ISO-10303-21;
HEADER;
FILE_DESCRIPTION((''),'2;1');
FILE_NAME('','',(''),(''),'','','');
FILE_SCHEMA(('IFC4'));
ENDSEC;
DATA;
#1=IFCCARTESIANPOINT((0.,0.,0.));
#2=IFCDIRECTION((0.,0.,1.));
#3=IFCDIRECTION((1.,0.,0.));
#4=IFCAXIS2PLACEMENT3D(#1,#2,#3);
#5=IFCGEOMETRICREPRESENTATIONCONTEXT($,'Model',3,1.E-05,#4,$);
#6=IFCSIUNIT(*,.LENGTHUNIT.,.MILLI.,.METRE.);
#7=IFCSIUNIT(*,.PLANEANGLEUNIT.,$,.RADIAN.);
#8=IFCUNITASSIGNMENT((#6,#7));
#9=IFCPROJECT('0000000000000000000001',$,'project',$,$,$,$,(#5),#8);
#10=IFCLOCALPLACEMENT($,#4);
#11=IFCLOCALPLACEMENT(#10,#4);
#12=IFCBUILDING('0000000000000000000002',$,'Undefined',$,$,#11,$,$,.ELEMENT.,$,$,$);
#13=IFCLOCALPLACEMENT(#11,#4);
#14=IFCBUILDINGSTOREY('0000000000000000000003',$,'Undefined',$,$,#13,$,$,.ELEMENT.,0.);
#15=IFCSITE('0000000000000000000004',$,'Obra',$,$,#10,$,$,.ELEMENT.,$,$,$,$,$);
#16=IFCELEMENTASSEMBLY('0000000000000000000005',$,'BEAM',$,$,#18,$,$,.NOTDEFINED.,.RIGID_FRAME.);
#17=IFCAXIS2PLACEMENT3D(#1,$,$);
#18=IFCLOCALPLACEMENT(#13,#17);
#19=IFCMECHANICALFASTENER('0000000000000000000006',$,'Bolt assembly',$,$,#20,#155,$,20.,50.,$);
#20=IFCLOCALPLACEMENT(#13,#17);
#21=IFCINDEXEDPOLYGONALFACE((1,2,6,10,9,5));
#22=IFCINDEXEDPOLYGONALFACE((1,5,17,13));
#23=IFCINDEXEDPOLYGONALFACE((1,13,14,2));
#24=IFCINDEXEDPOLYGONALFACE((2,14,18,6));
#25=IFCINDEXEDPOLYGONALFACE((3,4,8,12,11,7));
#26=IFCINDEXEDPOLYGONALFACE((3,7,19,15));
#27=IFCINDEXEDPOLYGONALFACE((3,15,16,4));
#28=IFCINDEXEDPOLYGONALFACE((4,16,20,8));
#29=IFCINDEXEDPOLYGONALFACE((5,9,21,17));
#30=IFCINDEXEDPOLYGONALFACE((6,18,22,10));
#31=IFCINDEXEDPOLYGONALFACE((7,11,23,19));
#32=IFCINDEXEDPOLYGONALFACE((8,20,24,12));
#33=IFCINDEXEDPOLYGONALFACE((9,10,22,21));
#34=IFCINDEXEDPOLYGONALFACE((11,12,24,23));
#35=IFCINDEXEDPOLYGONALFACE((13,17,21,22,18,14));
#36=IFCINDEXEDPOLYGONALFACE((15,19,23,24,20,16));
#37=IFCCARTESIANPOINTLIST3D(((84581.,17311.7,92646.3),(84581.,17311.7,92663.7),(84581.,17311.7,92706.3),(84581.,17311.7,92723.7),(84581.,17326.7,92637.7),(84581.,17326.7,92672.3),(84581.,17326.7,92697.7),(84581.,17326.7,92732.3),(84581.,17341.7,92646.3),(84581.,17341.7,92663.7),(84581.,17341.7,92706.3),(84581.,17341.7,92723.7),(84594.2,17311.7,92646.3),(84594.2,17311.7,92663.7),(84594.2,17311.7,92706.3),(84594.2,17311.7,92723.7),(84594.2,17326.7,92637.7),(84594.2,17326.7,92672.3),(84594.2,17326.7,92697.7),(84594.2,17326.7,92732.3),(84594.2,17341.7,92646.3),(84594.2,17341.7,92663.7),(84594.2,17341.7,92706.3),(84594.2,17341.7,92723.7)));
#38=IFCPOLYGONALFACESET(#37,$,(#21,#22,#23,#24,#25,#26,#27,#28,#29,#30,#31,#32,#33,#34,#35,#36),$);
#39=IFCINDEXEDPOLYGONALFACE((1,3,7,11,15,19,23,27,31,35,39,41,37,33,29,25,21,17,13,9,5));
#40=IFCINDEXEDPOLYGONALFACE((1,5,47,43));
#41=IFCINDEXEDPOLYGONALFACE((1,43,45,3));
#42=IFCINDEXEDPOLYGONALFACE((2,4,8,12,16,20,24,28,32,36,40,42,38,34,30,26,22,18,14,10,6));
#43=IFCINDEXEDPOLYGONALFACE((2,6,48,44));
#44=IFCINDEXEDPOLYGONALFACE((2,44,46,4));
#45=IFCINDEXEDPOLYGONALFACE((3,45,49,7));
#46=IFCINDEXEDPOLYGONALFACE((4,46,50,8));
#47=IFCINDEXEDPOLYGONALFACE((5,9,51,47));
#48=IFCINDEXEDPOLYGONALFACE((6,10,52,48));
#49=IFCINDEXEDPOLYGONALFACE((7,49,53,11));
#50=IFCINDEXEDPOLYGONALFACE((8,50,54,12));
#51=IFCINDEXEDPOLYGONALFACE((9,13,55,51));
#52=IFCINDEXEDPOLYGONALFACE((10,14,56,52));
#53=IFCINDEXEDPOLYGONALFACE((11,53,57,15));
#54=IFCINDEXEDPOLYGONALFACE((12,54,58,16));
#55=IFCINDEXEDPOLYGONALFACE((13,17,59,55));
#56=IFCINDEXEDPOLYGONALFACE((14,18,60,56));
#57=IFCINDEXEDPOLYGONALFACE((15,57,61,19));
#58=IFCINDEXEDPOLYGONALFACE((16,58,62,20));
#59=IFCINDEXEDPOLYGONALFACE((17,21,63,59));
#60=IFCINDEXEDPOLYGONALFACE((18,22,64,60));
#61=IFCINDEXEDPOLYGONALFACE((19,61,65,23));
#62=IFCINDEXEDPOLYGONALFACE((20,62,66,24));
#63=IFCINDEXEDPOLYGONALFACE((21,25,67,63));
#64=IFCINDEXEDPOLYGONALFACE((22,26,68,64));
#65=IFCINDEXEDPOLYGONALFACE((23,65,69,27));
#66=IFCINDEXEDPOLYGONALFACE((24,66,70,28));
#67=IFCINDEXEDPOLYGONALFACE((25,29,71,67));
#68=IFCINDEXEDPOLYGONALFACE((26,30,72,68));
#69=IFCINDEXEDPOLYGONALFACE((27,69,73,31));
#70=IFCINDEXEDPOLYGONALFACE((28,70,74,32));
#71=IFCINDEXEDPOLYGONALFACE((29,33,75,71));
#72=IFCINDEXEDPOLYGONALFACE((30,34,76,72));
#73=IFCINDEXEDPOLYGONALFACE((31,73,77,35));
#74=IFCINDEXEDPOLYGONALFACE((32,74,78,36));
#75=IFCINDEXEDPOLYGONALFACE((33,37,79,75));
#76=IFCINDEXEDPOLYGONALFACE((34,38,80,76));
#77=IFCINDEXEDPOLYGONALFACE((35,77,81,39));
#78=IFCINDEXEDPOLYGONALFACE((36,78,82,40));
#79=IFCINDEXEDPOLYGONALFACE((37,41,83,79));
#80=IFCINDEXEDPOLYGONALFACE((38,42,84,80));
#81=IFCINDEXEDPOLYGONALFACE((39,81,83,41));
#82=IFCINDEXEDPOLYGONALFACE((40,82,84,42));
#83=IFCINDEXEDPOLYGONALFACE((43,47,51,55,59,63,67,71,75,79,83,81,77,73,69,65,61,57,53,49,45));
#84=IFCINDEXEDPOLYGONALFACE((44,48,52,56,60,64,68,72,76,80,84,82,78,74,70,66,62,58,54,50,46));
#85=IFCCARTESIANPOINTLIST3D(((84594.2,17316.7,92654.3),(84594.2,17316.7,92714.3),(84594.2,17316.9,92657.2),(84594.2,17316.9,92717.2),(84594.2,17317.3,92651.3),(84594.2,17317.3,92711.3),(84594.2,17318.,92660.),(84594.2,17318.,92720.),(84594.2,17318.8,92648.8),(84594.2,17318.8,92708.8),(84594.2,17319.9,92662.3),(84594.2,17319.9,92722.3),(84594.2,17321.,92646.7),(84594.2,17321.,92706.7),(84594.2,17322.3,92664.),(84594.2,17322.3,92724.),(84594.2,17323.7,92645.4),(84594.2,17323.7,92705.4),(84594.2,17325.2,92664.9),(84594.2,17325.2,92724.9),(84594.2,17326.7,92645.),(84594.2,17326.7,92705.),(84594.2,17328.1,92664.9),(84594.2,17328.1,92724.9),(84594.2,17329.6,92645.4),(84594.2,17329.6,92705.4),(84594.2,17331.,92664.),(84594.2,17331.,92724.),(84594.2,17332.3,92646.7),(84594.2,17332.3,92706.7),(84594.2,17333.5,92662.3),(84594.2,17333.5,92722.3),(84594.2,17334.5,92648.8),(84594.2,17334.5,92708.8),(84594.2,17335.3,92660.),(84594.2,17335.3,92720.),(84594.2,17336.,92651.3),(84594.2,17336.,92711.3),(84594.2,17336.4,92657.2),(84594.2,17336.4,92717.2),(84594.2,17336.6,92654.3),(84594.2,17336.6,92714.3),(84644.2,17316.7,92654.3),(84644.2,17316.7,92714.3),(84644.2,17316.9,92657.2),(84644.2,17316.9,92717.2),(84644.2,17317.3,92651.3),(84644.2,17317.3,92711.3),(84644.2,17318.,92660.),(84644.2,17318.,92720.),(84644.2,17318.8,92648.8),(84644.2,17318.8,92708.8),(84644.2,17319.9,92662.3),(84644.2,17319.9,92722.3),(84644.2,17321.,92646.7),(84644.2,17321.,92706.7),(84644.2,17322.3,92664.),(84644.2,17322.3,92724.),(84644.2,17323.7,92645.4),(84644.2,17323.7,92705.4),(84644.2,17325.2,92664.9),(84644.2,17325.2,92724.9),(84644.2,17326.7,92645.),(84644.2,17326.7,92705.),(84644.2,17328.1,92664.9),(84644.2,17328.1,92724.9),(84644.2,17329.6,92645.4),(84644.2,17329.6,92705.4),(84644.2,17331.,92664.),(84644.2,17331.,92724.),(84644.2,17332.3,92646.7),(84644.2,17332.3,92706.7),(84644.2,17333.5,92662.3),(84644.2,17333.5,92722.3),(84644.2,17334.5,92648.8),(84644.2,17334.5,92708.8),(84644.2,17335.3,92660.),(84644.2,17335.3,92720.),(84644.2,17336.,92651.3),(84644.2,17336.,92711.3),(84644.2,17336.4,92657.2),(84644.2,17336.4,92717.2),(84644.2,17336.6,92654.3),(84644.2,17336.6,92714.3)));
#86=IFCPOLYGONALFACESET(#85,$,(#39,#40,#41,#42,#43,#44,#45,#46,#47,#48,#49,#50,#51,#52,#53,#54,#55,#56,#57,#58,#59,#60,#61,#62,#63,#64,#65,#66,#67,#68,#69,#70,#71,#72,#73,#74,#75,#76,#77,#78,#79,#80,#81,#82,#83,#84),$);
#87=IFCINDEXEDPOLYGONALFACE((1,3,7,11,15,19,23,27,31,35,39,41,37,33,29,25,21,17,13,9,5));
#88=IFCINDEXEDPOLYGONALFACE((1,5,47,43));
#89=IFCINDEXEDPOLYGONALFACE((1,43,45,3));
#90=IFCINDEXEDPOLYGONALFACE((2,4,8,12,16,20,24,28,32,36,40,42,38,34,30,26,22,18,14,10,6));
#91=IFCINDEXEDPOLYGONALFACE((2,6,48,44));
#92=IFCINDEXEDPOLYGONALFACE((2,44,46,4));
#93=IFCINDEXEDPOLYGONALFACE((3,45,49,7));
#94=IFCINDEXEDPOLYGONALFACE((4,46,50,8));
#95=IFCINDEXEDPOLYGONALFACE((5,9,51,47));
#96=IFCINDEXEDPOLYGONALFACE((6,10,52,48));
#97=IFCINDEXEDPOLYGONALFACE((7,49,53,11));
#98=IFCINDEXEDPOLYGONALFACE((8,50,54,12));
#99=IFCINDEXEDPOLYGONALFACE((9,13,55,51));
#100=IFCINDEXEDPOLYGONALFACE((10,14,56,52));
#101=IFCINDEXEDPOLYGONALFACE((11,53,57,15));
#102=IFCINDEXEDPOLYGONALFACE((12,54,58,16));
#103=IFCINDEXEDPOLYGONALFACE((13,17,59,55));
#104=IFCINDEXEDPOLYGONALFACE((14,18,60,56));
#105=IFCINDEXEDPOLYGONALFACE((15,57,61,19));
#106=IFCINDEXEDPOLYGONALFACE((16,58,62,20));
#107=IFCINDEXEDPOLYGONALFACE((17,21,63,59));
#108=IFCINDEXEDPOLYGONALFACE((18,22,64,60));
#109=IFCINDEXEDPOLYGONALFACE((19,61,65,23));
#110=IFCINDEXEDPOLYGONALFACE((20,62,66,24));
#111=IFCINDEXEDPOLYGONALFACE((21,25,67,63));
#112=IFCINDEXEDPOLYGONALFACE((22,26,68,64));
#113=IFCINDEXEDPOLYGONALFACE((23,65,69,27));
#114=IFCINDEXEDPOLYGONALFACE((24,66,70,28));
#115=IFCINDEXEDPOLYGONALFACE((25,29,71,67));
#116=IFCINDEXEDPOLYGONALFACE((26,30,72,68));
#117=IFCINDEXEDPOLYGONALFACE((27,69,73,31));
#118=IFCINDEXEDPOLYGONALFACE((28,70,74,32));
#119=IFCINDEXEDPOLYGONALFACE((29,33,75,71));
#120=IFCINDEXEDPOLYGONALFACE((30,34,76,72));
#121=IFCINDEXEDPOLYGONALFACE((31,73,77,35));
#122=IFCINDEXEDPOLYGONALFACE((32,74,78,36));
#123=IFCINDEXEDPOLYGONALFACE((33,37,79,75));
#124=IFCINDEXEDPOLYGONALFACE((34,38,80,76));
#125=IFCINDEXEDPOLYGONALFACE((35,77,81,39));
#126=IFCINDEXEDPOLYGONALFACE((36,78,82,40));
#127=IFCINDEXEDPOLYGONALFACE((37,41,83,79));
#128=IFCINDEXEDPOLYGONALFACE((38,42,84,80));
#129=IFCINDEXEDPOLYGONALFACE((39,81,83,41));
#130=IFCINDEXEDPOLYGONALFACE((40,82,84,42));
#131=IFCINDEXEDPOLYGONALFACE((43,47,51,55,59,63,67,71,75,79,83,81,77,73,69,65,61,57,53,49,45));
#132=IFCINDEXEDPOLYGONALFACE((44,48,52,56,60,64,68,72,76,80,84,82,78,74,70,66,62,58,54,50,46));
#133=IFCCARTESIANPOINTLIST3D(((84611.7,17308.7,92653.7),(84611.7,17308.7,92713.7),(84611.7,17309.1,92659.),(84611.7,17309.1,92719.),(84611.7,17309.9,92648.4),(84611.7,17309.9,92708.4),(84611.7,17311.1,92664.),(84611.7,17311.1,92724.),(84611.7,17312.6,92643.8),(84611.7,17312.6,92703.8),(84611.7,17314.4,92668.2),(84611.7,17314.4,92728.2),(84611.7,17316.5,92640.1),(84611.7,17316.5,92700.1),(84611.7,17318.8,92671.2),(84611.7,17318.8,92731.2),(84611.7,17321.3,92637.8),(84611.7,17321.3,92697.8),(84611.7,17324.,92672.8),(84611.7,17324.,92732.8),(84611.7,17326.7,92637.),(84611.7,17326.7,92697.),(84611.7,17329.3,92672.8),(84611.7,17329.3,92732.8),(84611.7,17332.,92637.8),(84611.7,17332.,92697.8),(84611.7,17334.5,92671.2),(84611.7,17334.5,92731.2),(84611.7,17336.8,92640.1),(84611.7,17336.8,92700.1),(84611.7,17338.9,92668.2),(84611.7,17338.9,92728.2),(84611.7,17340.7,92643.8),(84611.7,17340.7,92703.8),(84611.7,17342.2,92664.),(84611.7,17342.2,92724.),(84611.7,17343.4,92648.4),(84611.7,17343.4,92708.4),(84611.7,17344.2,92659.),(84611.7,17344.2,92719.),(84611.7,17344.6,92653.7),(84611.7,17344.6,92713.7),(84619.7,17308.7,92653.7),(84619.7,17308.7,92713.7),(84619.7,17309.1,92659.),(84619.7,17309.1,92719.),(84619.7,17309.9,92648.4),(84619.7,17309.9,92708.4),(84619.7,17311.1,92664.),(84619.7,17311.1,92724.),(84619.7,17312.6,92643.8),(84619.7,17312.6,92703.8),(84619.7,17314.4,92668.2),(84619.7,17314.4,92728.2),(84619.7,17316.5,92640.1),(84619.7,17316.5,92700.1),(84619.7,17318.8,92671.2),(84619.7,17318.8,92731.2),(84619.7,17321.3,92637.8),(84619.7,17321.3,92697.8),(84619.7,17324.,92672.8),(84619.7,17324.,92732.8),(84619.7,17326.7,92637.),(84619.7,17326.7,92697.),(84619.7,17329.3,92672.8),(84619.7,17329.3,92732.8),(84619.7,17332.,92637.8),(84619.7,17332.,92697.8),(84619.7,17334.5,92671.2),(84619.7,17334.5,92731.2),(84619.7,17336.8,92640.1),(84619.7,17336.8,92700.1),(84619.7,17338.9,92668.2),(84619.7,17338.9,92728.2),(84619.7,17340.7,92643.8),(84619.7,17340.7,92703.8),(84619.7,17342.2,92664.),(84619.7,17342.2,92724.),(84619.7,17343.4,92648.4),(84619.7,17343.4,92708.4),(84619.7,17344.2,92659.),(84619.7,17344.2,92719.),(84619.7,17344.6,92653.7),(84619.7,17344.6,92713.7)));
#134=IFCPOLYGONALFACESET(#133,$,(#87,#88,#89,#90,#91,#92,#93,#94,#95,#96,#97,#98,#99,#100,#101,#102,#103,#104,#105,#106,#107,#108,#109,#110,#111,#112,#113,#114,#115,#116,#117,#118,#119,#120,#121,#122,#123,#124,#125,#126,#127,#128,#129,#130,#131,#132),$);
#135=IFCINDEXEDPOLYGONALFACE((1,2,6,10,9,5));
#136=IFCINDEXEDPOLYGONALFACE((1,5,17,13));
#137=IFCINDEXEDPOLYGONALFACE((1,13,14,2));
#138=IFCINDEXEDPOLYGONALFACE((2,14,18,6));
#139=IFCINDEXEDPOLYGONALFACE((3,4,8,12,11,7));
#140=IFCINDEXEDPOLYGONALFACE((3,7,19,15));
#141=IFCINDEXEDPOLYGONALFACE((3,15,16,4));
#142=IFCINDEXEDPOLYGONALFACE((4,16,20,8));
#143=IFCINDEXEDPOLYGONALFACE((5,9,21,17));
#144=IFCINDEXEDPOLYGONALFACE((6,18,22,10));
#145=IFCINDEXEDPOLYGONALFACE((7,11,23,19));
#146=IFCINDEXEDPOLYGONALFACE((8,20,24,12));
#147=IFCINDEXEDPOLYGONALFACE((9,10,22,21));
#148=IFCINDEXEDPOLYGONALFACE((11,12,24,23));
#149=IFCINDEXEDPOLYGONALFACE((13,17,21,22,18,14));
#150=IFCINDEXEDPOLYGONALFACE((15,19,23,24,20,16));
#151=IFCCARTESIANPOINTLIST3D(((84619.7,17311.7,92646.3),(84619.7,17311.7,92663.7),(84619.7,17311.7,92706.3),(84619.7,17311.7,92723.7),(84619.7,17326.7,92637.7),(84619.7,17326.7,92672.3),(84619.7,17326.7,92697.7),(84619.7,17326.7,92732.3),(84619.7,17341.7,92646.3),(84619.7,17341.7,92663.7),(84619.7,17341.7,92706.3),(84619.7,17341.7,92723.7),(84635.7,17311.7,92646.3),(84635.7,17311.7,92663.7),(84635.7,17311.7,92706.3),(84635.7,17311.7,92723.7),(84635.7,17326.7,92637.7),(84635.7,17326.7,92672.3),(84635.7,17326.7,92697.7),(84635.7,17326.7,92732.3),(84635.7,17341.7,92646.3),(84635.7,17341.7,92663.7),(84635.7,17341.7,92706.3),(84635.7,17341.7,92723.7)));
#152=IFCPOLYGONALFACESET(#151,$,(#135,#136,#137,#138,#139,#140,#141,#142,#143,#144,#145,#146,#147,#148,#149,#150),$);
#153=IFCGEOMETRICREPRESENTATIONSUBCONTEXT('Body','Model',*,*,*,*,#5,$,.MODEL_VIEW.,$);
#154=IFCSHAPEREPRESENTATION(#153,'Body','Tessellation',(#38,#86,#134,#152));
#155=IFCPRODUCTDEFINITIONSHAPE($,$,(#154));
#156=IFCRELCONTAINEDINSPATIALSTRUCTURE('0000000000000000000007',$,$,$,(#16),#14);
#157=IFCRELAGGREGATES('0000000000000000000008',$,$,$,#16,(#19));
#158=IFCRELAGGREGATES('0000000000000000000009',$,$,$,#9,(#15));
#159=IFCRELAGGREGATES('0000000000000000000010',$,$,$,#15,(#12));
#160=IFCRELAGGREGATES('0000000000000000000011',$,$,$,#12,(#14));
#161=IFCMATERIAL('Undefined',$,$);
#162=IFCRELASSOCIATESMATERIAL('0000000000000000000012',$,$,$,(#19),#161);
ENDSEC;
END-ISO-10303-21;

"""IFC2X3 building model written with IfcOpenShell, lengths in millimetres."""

from ifc_helpers import new_model, si_unit, frame, origin_with_axes, origin_2d_with_axis, place, context, subcontext, project, spatial, polyline, circle, outline, extrude, source, transform, mapped, material, element, aggregate, save


model = new_model("IFC2X3")

# Units and contexts
model_context = context("Model", 3, precision=1e-05, world=origin_with_axes())
body_context = subcontext(model_context, "Body", "Model", "MODEL_VIEW")
ifc_project = project(units=[si_unit("LENGTHUNIT", "METRE", prefix="MILLI"), si_unit("PLANEANGLEUNIT", "RADIAN")], contexts=[model_context])

# Site, building, storey
site_placement = place(None, origin_with_axes())
site = spatial("IfcSite", under=ifc_project, at=site_placement, Name="Obra", CompositionType="ELEMENT")
building_placement = place(site_placement, origin_with_axes())
building = spatial("IfcBuilding", under=site, at=building_placement, Name="Undefined", CompositionType="ELEMENT")
storey_placement = place(building_placement, origin_with_axes())
storey = spatial("IfcBuildingStorey", under=building, at=storey_placement, Name="Undefined", CompositionType="ELEMENT", Elevation=0.0)

# Shared definitions
ifc_material_1 = material(Name="Undefined")

# Shared definitions
shared_shape_1 = source(origin_with_axes(), body_context, "Body", "SweptSolid", [
    extrude(outline(polyline([(17.3, 0.0), (8.7, 15.0), (-8.7, 15.0), (-17.3, 0.0), (-8.7, -15.0), (8.7, -15.0), (17.3, 0.0)])), frame((0.0, -27.0, 0.0), z_axis=(0.0, 1.0, 0.0), x_axis=(1.0, 0.0, 0.0)), (0.0, 0.0, 1.0), 13.2),
    extrude(circle(Radius=10.0, at=origin_2d_with_axis()), frame((0.0, -13.8, 0.0), z_axis=(0.0, 1.0, 0.0), x_axis=(1.0, 0.0, 0.0)), (0.0, 0.0, 1.0), 50.0),
    extrude(circle(Radius=18.0, at=origin_2d_with_axis()), frame((0.0, 3.7, 0.0), z_axis=(0.0, 1.0, 0.0), x_axis=(1.0, 0.0, 0.0)), (0.0, 0.0, 1.0), 8.0),
    extrude(outline(polyline([(17.3, 0.0), (8.7, 15.0), (-8.7, 15.0), (-17.3, 0.0), (-8.7, -15.0), (8.7, -15.0), (17.3, 0.0)])), frame((0.0, 11.7, 0.0), z_axis=(0.0, 1.0, 0.0), x_axis=(1.0, 0.0, 0.0)), (0.0, 0.0, 1.0), 16.0),
])

# Element assembly, mechanical fastener
assembly_1_placement = place(storey_placement, origin_with_axes())
assembly_1 = element("IfcElementAssembly", 1, at=assembly_1_placement, inside=storey, Name="BEAM", AssemblyPlace="NOTDEFINED", PredefinedType="RIGID_FRAME")
mechanical_fastener_1_placement = place(assembly_1_placement, frame((84607.9, 17366.7, 92850.0), z_axis=(0.0, -1.0, 0.0), x_axis=(0.0, 0.0, -1.0)))
mechanical_fastener_1 = element("IfcMechanicalFastener", 2, at=mechanical_fastener_1_placement, material=ifc_material_1, Name="Bolt assembly", NominalDiameter=20.0, NominalLength=50.0, context=body_context, shape_type="MappedRepresentation", body=[
    mapped(shared_shape_1, transform((135.0, 0.0, 40.0))),
    mapped(shared_shape_1, transform((195.0, 0.0, 40.0))),
])
aggregate(assembly_1, [mechanical_fastener_1])

save(model, "model.ifc")
